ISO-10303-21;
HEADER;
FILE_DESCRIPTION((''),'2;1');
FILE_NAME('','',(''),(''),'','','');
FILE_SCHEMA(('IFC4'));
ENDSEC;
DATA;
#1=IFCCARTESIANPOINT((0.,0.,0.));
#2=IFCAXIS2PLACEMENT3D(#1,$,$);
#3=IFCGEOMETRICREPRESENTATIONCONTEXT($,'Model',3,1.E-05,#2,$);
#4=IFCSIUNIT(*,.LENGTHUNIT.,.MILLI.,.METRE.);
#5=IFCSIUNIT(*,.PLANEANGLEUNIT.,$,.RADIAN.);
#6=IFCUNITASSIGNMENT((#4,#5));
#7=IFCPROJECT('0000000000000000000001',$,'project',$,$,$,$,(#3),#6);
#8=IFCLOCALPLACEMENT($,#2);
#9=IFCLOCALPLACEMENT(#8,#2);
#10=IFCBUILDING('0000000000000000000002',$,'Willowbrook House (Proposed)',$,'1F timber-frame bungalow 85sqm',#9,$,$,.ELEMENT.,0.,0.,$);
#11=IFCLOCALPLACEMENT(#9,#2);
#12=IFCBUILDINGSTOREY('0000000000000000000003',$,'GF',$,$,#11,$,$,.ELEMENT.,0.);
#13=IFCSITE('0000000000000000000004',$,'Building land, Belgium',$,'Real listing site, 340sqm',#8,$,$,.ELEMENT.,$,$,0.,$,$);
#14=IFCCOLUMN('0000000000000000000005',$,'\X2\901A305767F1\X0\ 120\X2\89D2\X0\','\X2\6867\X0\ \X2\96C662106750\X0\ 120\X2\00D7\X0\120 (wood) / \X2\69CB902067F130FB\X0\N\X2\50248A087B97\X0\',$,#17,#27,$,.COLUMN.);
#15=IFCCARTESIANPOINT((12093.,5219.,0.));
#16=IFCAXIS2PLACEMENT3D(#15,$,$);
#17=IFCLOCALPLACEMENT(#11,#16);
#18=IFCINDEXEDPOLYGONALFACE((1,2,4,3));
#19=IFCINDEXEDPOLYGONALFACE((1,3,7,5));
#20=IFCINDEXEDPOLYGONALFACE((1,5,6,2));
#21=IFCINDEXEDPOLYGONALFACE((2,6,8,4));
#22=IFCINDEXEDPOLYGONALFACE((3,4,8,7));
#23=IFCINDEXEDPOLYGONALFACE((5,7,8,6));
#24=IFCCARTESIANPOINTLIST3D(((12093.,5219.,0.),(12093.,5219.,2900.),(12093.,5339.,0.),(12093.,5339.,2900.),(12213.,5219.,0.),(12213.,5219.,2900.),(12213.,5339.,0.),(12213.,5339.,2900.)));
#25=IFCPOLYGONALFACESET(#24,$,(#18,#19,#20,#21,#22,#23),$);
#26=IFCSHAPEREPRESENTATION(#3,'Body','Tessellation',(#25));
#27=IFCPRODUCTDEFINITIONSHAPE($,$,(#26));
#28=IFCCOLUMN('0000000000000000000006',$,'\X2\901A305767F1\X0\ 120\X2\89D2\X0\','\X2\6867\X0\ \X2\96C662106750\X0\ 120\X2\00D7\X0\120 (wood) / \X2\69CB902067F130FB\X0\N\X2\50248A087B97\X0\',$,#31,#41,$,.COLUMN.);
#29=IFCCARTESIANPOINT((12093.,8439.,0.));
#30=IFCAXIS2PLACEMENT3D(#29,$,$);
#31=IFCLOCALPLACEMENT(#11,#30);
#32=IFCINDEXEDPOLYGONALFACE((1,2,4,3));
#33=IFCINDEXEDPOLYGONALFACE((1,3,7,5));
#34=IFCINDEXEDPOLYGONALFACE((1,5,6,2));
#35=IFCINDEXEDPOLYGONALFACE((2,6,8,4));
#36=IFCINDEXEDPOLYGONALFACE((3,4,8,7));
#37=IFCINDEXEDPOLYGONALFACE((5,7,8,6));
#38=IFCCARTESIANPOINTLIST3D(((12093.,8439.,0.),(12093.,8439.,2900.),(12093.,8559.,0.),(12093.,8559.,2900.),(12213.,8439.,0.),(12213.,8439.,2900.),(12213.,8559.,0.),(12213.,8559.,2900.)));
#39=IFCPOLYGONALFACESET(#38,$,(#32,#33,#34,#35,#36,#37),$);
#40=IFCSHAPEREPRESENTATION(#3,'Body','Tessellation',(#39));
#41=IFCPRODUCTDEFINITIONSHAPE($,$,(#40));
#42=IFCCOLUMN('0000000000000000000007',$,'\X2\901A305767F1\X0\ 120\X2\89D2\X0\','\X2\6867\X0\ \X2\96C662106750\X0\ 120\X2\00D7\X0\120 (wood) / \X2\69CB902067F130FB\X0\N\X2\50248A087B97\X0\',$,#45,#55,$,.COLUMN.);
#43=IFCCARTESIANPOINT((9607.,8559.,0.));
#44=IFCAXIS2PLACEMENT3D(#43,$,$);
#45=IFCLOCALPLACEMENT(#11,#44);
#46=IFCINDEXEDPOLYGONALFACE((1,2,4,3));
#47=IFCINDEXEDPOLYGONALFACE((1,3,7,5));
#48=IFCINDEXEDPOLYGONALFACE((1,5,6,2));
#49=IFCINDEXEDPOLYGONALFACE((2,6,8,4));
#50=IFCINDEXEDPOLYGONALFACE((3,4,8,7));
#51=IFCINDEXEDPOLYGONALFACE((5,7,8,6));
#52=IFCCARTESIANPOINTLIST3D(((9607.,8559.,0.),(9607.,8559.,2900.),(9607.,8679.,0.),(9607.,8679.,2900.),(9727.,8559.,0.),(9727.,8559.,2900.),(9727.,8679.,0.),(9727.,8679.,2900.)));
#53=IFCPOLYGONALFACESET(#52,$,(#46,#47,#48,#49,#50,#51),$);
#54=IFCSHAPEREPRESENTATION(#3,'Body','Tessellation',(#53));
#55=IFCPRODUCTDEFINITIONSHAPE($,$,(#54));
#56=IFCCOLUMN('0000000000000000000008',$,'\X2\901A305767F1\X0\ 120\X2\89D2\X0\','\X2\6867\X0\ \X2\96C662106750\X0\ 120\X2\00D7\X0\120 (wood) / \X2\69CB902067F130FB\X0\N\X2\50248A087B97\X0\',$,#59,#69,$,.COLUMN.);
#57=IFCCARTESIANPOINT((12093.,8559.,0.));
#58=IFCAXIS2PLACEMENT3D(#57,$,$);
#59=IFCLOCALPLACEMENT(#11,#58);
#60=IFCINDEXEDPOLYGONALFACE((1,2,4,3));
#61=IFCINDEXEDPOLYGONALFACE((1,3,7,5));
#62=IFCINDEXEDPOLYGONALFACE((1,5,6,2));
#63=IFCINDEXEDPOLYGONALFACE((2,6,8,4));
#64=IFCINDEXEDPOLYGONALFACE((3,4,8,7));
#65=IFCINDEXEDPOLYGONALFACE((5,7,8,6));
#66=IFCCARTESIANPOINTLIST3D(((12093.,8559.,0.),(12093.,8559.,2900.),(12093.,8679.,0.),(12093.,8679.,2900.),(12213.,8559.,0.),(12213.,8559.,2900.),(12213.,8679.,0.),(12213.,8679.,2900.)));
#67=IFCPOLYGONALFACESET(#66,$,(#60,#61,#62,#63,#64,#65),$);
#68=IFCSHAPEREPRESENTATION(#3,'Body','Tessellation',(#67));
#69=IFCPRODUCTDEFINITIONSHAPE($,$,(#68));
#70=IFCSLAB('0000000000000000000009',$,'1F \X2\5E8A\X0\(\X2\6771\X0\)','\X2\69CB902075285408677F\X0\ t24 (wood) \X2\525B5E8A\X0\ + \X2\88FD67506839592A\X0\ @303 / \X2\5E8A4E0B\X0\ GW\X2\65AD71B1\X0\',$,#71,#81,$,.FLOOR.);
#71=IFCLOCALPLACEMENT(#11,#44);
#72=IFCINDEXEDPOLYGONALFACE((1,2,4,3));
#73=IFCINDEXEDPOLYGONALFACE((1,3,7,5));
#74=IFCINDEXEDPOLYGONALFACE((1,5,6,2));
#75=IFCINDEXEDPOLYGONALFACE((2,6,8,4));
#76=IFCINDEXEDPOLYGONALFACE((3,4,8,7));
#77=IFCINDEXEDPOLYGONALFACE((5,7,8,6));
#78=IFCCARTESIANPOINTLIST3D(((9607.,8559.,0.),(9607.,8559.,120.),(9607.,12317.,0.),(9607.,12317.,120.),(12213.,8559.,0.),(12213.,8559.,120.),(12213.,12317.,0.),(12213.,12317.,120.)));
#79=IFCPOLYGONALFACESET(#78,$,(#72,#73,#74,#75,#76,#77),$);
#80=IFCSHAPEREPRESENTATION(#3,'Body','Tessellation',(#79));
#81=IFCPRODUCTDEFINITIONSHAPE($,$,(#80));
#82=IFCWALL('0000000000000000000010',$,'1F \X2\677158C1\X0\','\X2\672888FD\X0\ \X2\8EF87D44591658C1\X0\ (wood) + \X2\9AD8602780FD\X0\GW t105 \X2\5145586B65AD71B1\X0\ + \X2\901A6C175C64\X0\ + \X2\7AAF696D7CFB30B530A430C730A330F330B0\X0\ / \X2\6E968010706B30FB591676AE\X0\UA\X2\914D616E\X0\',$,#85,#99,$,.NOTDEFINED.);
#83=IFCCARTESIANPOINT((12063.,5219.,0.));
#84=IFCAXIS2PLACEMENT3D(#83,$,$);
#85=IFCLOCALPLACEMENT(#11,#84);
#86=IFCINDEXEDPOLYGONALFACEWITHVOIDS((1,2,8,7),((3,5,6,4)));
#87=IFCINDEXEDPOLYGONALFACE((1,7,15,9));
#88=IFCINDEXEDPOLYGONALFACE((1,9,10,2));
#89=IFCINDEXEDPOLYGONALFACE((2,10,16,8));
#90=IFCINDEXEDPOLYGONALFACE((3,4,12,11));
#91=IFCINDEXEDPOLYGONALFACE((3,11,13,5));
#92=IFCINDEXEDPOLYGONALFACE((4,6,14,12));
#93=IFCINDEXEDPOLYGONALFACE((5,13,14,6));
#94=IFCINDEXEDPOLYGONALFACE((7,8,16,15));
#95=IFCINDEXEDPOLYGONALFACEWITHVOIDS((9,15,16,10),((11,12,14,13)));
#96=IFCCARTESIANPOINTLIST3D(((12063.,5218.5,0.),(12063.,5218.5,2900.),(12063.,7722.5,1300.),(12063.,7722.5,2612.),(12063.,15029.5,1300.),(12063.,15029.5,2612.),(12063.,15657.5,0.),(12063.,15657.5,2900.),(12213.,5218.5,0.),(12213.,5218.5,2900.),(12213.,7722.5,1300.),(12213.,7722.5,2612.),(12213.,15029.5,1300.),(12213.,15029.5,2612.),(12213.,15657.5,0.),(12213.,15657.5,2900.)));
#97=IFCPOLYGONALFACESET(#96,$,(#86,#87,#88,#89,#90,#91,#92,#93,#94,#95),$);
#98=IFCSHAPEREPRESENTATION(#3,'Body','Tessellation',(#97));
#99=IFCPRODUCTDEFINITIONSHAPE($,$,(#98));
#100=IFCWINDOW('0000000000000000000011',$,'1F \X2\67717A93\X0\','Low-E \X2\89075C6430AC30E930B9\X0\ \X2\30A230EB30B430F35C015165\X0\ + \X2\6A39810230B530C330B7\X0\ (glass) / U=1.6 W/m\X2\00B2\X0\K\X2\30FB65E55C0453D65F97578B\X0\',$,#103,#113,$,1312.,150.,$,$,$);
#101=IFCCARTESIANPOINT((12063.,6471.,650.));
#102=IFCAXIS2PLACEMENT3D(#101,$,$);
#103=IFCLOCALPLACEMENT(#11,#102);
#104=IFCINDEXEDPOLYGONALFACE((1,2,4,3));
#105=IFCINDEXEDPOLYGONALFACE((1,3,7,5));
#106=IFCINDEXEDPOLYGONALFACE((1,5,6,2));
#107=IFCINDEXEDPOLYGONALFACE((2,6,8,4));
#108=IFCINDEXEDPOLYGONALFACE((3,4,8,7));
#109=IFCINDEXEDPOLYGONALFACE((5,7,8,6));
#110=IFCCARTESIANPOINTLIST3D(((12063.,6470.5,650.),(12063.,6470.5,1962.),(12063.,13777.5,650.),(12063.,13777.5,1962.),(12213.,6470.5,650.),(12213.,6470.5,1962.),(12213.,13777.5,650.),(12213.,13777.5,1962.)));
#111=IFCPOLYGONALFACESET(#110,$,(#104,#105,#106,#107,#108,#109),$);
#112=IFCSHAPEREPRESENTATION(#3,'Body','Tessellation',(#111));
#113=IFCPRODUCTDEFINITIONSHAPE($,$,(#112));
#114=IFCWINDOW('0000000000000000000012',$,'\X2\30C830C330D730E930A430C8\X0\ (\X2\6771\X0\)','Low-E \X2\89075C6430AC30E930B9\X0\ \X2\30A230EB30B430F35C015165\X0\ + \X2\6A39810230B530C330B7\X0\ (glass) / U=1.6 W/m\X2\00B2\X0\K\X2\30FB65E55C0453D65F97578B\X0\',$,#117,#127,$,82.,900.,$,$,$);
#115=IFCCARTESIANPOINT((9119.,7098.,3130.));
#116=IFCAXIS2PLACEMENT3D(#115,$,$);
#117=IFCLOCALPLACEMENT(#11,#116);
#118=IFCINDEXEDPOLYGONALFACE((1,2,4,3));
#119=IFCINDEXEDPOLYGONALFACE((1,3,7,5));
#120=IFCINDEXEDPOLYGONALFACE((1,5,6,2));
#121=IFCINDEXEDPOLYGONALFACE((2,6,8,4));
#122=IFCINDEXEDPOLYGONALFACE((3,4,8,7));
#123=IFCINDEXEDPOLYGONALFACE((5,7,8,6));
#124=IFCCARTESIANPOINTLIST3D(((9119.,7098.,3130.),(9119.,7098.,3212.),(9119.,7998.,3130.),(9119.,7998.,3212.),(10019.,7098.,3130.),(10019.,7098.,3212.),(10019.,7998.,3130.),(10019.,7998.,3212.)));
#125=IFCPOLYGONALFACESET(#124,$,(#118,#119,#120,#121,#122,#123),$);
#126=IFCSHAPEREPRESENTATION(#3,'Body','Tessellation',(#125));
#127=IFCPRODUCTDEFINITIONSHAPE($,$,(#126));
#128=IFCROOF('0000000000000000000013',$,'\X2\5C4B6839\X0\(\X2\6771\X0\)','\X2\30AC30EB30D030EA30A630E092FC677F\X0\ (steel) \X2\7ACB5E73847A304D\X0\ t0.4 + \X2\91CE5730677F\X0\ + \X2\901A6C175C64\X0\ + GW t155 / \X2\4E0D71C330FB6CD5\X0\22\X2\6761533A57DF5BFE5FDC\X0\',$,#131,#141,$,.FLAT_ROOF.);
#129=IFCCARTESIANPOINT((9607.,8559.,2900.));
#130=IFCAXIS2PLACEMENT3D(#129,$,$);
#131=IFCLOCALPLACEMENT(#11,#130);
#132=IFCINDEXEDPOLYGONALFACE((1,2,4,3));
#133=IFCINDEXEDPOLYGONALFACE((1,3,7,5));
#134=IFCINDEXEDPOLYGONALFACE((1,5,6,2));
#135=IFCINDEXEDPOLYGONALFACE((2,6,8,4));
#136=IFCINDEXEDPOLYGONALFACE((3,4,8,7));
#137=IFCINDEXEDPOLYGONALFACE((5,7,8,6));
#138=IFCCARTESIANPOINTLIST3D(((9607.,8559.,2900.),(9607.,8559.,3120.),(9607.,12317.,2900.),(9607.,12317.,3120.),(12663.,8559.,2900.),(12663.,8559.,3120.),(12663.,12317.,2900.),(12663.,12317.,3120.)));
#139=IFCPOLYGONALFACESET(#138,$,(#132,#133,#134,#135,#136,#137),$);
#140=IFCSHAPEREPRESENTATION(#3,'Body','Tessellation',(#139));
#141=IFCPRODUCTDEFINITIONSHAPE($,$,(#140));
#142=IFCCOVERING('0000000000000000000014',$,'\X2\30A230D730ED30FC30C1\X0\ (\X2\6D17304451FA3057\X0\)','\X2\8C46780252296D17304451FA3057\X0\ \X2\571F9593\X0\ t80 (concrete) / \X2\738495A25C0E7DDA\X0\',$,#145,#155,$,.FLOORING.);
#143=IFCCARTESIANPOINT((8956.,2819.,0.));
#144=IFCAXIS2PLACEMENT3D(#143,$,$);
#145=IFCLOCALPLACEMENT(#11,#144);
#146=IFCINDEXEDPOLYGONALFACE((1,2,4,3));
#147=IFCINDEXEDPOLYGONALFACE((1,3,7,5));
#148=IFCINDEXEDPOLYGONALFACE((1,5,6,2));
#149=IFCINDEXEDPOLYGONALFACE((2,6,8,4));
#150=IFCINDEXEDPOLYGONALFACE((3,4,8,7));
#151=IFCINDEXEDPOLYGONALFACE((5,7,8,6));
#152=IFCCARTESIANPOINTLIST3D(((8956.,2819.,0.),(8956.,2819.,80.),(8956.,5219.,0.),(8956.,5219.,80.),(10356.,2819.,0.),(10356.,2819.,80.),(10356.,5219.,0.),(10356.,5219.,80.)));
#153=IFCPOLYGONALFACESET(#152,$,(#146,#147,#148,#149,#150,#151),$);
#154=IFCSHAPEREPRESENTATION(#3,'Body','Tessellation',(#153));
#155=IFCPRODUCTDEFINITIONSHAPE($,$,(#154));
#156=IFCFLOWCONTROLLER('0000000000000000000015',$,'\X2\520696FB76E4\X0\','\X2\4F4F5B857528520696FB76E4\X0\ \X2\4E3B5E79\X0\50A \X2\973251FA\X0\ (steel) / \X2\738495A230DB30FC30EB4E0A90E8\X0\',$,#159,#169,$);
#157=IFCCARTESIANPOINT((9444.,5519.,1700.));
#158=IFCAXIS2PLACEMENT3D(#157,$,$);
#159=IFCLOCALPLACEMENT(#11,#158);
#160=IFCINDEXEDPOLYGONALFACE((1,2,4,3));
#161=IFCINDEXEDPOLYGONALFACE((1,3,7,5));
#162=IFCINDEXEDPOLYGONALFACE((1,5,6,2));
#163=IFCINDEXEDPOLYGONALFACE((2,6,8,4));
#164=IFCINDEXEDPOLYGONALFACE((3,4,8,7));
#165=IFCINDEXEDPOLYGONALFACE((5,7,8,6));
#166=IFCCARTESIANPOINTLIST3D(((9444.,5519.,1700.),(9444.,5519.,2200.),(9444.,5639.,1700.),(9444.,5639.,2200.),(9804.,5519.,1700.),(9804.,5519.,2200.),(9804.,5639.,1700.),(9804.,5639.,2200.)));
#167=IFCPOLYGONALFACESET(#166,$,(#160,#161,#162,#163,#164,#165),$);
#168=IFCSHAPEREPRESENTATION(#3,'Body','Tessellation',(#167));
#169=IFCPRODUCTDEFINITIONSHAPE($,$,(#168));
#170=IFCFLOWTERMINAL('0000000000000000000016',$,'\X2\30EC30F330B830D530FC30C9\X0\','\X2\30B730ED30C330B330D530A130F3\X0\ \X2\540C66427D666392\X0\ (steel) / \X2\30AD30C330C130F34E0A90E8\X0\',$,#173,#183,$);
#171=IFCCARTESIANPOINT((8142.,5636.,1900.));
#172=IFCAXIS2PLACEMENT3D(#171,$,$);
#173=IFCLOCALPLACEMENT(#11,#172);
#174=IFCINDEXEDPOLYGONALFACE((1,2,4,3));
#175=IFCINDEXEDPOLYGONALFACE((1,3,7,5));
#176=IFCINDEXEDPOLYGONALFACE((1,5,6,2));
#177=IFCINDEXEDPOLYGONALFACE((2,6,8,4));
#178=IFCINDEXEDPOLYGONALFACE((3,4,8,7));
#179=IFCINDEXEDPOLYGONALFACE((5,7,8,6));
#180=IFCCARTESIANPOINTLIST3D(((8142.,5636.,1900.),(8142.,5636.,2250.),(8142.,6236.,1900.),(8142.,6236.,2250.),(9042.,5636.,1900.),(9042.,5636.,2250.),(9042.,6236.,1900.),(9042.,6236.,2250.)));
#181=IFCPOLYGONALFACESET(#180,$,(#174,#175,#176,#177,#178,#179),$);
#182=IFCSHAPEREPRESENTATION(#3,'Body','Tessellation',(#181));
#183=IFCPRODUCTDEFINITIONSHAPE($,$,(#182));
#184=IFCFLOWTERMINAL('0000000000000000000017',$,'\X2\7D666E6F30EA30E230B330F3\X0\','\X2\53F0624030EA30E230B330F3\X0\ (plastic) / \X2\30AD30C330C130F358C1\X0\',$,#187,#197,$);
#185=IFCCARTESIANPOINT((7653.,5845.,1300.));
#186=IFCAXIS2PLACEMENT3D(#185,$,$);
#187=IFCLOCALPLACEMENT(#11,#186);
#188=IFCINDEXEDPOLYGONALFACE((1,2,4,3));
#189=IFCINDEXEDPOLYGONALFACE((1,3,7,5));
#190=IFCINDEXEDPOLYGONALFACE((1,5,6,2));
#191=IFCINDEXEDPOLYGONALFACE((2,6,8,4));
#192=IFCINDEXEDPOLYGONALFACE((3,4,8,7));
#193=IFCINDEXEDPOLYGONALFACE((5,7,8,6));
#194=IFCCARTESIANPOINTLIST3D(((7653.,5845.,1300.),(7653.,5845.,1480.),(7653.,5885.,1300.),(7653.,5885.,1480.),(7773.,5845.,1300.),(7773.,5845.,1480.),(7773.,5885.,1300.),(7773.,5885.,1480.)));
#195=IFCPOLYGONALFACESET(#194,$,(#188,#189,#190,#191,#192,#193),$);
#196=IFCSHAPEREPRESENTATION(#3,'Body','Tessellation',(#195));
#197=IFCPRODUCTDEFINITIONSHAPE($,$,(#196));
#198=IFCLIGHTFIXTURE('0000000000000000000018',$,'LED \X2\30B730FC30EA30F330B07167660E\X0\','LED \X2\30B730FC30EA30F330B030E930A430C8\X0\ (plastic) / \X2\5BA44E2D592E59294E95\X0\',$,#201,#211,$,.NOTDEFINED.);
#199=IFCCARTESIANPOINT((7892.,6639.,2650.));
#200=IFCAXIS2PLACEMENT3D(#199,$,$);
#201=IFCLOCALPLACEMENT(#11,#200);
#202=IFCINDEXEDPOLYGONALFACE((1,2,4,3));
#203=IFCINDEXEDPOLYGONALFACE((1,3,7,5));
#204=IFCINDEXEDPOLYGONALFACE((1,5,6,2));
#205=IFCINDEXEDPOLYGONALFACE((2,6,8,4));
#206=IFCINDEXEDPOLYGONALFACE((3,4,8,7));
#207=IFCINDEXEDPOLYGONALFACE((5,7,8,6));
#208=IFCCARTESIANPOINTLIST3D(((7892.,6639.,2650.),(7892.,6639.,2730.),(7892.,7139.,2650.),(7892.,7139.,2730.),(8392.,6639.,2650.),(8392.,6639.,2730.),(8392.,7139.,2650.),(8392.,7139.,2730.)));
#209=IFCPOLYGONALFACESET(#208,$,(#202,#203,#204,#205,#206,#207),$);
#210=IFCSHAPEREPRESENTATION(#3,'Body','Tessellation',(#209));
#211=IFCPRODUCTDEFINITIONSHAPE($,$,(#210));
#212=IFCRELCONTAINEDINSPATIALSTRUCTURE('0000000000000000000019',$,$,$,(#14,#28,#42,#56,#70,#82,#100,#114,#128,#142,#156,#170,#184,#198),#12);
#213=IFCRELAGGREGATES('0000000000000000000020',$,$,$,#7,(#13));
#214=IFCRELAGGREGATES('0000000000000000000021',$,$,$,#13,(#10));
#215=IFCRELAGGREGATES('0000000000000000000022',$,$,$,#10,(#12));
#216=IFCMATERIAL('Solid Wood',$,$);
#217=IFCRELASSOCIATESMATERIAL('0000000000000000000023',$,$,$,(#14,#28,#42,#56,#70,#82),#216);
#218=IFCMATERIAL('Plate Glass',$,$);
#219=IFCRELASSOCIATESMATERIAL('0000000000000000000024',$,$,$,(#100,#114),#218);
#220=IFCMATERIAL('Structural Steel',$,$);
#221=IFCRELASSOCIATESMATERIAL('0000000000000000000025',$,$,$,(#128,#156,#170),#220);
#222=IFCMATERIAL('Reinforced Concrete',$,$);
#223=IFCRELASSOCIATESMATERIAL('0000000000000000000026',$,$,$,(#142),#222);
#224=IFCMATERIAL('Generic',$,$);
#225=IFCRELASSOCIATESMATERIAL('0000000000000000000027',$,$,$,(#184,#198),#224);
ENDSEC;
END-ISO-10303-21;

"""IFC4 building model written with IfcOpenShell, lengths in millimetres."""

from ifc_helpers import new_model, si_unit, frame, frame_2d, origin, place, context, project, spatial, rectangle, extrude, material, element, fill, save


model = new_model("IFC4")

# Units and contexts
model_context = context("Model", 3, precision=1e-05, world=origin())
ifc_project = project(units=[si_unit("LENGTHUNIT", "METRE", prefix="MILLI"), si_unit("PLANEANGLEUNIT", "RADIAN")], contexts=[model_context])

# Site, building, storey
site_placement = place(None, origin())
site = spatial("IfcSite", under=ifc_project, at=site_placement, Name="Building land, Belgium", ObjectType="Real listing site, 340sqm", CompositionType="ELEMENT", RefElevation=0.0)
building_placement = place(site_placement, origin())
building = spatial("IfcBuilding", under=site, at=building_placement, Name="Willowbrook House (Proposed)", ObjectType="1F timber-frame bungalow 85sqm", CompositionType="ELEMENT", ElevationOfRefHeight=0.0, ElevationOfTerrain=0.0)
storey_placement = place(building_placement, origin())
storey = spatial("IfcBuildingStorey", under=building, at=storey_placement, Name="GF", CompositionType="ELEMENT", Elevation=0.0)

# Columns
ifc_material_1 = material(Name="Solid Wood")
column_1_placement = place(storey_placement, frame((12093.0, 5219.0, 0.0)))
element("IfcColumn", 1, at=column_1_placement, inside=storey, material=ifc_material_1, Name="通し柱 120角", Description="桧 集成材 120×120 (wood) / 構造柱・N値計算", PredefinedType="COLUMN", context=model_context, shape_type="SweptSolid", body=[
    extrude(rectangle(XDim=120.0, YDim=120.0, at=frame_2d((60.0, 60.0))), frame((12093.0, 5219.0, 0.0)), (0.0, 0.0, 1.0), 2900.0),
])
column_2_placement = place(storey_placement, frame((12093.0, 8439.0, 0.0)))
element("IfcColumn", 2, at=column_2_placement, inside=storey, material=ifc_material_1, Name="通し柱 120角", Description="桧 集成材 120×120 (wood) / 構造柱・N値計算", PredefinedType="COLUMN", context=model_context, shape_type="SweptSolid", body=[
    extrude(rectangle(XDim=120.0, YDim=120.0, at=frame_2d((60.0, 60.0))), frame((12093.0, 8439.0, 0.0)), (0.0, 0.0, 1.0), 2900.0),
])
column_3_placement = place(storey_placement, frame((9607.0, 8559.0, 0.0)))
element("IfcColumn", 3, at=column_3_placement, inside=storey, material=ifc_material_1, Name="通し柱 120角", Description="桧 集成材 120×120 (wood) / 構造柱・N値計算", PredefinedType="COLUMN", context=model_context, shape_type="SweptSolid", body=[
    extrude(rectangle(XDim=120.0, YDim=120.0, at=frame_2d((60.0, 60.0))), frame((9607.0, 8559.0, 0.0)), (0.0, 0.0, 1.0), 2900.0),
])
column_4_placement = place(storey_placement, frame((12093.0, 8559.0, 0.0)))
element("IfcColumn", 4, at=column_4_placement, inside=storey, material=ifc_material_1, Name="通し柱 120角", Description="桧 集成材 120×120 (wood) / 構造柱・N値計算", PredefinedType="COLUMN", context=model_context, shape_type="SweptSolid", body=[
    extrude(rectangle(XDim=120.0, YDim=120.0, at=frame_2d((60.0, 60.0))), frame((12093.0, 8559.0, 0.0)), (0.0, 0.0, 1.0), 2900.0),
])

# Slab
slab_placement = place(storey_placement, frame((9607.0, 8559.0, 0.0)))
element("IfcSlab", 5, at=slab_placement, inside=storey, material=ifc_material_1, Name="1F 床(東)", Description="構造用合板 t24 (wood) 剛床 + 製材根太 @303 / 床下 GW断熱", PredefinedType="FLOOR", context=model_context, shape_type="SweptSolid", body=[
    extrude(rectangle(XDim=2606.0, YDim=3758.0, at=frame_2d((1303.0, 1879.0))), frame((9607.0, 8559.0, 0.0)), (0.0, 0.0, 1.0), 120.0),
])

# Wall, opening, window
wall_1_placement = place(storey_placement, frame((12063.0, 5219.0, 0.0)))
wall_1 = element("IfcWall", 6, at=wall_1_placement, inside=storey, material=ifc_material_1, Name="1F 東壁", Description="木製 軸組外壁 (wood) + 高性能GW t105 充填断熱 + 通気層 + 窯業系サイディング / 準耐火・外皮UA配慮", PredefinedType="NOTDEFINED", context=model_context, shape_type="SweptSolid", body=[
    extrude(rectangle(XDim=150.0, YDim=10439.0, at=frame_2d((75.0, 5219.0))), frame((12063.0, 5219.0, 0.0)), (0.0, 0.0, 1.0), 2900.0),
])
opening_placement = place(storey_placement, frame((12063.0, 6471.0, 650.0)))
opening = element("IfcOpeningElement", 7, at=opening_placement, cuts=wall_1, PredefinedType="NOTDEFINED", context=model_context, shape_type="SweptSolid", body=[
    extrude(rectangle(XDim=150.0, YDim=7307.0, at=frame_2d((75.0, 3653.0))), frame((12063.0, 6471.0, 650.0)), (0.0, 0.0, 1.0), 1312.0),
])
ifc_material_2 = material(Name="Plate Glass")
window_1_placement = place(storey_placement, frame((12063.0, 6471.0, 650.0)))
window_1 = element("IfcWindow", 8, at=window_1_placement, inside=storey, material=ifc_material_2, Name="1F 東窓", Description="Low-E 複層ガラス アルゴン封入 + 樹脂サッシ (glass) / U=1.6 W/m²K・日射取得型", OverallHeight=1312.0, OverallWidth=150.0, context=model_context, shape_type="SweptSolid", body=[
    extrude(rectangle(XDim=150.0, YDim=7307.0, at=frame_2d((75.0, 3653.0))), frame((12063.0, 6471.0, 650.0)), (0.0, 0.0, 1.0), 1312.0),
])
fill(opening, window_1)

# Window
window_2_placement = place(storey_placement, frame((9119.0, 7098.0, 3130.0)))
element("IfcWindow", 9, at=window_2_placement, inside=storey, material=ifc_material_2, Name="トップライト (東)", Description="Low-E 複層ガラス アルゴン封入 + 樹脂サッシ (glass) / U=1.6 W/m²K・日射取得型", OverallHeight=82.0, OverallWidth=900.0, context=model_context, shape_type="SweptSolid", body=[
    extrude(rectangle(XDim=900.0, YDim=900.0, at=frame_2d((450.0, 450.0))), frame((9119.0, 7098.0, 3130.0)), (0.0, 0.0, 1.0), 82.0),
])

# Roof
ifc_material_3 = material(Name="Structural Steel")
roof_placement = place(storey_placement, frame((9607.0, 8559.0, 2900.0)))
element("IfcRoof", 10, at=roof_placement, inside=storey, material=ifc_material_3, Name="屋根(東)", Description="ガルバリウム鋼板 (steel) 立平葺き t0.4 + 野地板 + 通気層 + GW t155 / 不燃・法22条区域対応", PredefinedType="FLAT_ROOF", context=model_context, shape_type="SweptSolid", body=[
    extrude(rectangle(XDim=3056.0, YDim=3758.0, at=frame_2d((1528.0, 1879.0))), frame((9607.0, 8559.0, 2900.0)), (0.0, 0.0, 1.0), 220.0),
])

# Covering
ifc_material_4 = material(Name="Reinforced Concrete")
covering_placement = place(storey_placement, frame((8956.0, 2819.0, 0.0)))
element("IfcCovering", 11, at=covering_placement, inside=storey, material=ifc_material_4, Name="アプローチ (洗い出し)", Description="豆砂利洗い出し 土間 t80 (concrete) / 玄関導線", PredefinedType="FLOORING", context=model_context, shape_type="SweptSolid", body=[
    extrude(rectangle(XDim=1400.0, YDim=2400.0, at=frame_2d((700.0, 1200.0))), frame((8956.0, 2819.0, 0.0)), (0.0, 0.0, 1.0), 80.0),
])

# Flow controller
flow_controller_placement = place(storey_placement, frame((9444.0, 5519.0, 1700.0)))
element("IfcFlowController", 12, at=flow_controller_placement, inside=storey, material=ifc_material_3, Name="分電盤", Description="住宅用分電盤 主幹50A 露出 (steel) / 玄関ホール上部", context=model_context, shape_type="SweptSolid", body=[
    extrude(rectangle(XDim=360.0, YDim=120.0, at=frame_2d((180.0, 60.0))), frame((9444.0, 5519.0, 1700.0)), (0.0, 0.0, 1.0), 500.0),
])

# Flow terminals
flow_terminal_1_placement = place(storey_placement, frame((8142.0, 5636.0, 1900.0)))
element("IfcFlowTerminal", 13, at=flow_terminal_1_placement, inside=storey, material=ifc_material_3, Name="レンジフード", Description="シロッコファン 同時給排 (steel) / キッチン上部", context=model_context, shape_type="SweptSolid", body=[
    extrude(rectangle(XDim=900.0, YDim=600.0, at=frame_2d((450.0, 300.0))), frame((8142.0, 5636.0, 1900.0)), (0.0, 0.0, 1.0), 350.0),
])
ifc_material_5 = material(Name="Generic")
flow_terminal_2_placement = place(storey_placement, frame((7653.0, 5845.0, 1300.0)))
element("IfcFlowTerminal", 14, at=flow_terminal_2_placement, inside=storey, material=ifc_material_5, Name="給湯リモコン", Description="台所リモコン (plastic) / キッチン壁", context=model_context, shape_type="SweptSolid", body=[
    extrude(rectangle(XDim=120.0, YDim=40.0, at=frame_2d((60.0, 20.0))), frame((7653.0, 5845.0, 1300.0)), (0.0, 0.0, 1.0), 180.0),
])

# Light fixture
light_fixture_placement = place(storey_placement, frame((7892.0, 6639.0, 2650.0)))
element("IfcLightFixture", 15, at=light_fixture_placement, inside=storey, material=ifc_material_5, Name="LED シーリング照明", Description="LED シーリングライト (plastic) / 室中央天井", PredefinedType="NOTDEFINED", context=model_context, shape_type="SweptSolid", body=[
    extrude(rectangle(XDim=500.0, YDim=500.0, at=frame_2d((250.0, 250.0))), frame((7892.0, 6639.0, 2650.0)), (0.0, 0.0, 1.0), 80.0),
])

save(model, "model.ifc")
